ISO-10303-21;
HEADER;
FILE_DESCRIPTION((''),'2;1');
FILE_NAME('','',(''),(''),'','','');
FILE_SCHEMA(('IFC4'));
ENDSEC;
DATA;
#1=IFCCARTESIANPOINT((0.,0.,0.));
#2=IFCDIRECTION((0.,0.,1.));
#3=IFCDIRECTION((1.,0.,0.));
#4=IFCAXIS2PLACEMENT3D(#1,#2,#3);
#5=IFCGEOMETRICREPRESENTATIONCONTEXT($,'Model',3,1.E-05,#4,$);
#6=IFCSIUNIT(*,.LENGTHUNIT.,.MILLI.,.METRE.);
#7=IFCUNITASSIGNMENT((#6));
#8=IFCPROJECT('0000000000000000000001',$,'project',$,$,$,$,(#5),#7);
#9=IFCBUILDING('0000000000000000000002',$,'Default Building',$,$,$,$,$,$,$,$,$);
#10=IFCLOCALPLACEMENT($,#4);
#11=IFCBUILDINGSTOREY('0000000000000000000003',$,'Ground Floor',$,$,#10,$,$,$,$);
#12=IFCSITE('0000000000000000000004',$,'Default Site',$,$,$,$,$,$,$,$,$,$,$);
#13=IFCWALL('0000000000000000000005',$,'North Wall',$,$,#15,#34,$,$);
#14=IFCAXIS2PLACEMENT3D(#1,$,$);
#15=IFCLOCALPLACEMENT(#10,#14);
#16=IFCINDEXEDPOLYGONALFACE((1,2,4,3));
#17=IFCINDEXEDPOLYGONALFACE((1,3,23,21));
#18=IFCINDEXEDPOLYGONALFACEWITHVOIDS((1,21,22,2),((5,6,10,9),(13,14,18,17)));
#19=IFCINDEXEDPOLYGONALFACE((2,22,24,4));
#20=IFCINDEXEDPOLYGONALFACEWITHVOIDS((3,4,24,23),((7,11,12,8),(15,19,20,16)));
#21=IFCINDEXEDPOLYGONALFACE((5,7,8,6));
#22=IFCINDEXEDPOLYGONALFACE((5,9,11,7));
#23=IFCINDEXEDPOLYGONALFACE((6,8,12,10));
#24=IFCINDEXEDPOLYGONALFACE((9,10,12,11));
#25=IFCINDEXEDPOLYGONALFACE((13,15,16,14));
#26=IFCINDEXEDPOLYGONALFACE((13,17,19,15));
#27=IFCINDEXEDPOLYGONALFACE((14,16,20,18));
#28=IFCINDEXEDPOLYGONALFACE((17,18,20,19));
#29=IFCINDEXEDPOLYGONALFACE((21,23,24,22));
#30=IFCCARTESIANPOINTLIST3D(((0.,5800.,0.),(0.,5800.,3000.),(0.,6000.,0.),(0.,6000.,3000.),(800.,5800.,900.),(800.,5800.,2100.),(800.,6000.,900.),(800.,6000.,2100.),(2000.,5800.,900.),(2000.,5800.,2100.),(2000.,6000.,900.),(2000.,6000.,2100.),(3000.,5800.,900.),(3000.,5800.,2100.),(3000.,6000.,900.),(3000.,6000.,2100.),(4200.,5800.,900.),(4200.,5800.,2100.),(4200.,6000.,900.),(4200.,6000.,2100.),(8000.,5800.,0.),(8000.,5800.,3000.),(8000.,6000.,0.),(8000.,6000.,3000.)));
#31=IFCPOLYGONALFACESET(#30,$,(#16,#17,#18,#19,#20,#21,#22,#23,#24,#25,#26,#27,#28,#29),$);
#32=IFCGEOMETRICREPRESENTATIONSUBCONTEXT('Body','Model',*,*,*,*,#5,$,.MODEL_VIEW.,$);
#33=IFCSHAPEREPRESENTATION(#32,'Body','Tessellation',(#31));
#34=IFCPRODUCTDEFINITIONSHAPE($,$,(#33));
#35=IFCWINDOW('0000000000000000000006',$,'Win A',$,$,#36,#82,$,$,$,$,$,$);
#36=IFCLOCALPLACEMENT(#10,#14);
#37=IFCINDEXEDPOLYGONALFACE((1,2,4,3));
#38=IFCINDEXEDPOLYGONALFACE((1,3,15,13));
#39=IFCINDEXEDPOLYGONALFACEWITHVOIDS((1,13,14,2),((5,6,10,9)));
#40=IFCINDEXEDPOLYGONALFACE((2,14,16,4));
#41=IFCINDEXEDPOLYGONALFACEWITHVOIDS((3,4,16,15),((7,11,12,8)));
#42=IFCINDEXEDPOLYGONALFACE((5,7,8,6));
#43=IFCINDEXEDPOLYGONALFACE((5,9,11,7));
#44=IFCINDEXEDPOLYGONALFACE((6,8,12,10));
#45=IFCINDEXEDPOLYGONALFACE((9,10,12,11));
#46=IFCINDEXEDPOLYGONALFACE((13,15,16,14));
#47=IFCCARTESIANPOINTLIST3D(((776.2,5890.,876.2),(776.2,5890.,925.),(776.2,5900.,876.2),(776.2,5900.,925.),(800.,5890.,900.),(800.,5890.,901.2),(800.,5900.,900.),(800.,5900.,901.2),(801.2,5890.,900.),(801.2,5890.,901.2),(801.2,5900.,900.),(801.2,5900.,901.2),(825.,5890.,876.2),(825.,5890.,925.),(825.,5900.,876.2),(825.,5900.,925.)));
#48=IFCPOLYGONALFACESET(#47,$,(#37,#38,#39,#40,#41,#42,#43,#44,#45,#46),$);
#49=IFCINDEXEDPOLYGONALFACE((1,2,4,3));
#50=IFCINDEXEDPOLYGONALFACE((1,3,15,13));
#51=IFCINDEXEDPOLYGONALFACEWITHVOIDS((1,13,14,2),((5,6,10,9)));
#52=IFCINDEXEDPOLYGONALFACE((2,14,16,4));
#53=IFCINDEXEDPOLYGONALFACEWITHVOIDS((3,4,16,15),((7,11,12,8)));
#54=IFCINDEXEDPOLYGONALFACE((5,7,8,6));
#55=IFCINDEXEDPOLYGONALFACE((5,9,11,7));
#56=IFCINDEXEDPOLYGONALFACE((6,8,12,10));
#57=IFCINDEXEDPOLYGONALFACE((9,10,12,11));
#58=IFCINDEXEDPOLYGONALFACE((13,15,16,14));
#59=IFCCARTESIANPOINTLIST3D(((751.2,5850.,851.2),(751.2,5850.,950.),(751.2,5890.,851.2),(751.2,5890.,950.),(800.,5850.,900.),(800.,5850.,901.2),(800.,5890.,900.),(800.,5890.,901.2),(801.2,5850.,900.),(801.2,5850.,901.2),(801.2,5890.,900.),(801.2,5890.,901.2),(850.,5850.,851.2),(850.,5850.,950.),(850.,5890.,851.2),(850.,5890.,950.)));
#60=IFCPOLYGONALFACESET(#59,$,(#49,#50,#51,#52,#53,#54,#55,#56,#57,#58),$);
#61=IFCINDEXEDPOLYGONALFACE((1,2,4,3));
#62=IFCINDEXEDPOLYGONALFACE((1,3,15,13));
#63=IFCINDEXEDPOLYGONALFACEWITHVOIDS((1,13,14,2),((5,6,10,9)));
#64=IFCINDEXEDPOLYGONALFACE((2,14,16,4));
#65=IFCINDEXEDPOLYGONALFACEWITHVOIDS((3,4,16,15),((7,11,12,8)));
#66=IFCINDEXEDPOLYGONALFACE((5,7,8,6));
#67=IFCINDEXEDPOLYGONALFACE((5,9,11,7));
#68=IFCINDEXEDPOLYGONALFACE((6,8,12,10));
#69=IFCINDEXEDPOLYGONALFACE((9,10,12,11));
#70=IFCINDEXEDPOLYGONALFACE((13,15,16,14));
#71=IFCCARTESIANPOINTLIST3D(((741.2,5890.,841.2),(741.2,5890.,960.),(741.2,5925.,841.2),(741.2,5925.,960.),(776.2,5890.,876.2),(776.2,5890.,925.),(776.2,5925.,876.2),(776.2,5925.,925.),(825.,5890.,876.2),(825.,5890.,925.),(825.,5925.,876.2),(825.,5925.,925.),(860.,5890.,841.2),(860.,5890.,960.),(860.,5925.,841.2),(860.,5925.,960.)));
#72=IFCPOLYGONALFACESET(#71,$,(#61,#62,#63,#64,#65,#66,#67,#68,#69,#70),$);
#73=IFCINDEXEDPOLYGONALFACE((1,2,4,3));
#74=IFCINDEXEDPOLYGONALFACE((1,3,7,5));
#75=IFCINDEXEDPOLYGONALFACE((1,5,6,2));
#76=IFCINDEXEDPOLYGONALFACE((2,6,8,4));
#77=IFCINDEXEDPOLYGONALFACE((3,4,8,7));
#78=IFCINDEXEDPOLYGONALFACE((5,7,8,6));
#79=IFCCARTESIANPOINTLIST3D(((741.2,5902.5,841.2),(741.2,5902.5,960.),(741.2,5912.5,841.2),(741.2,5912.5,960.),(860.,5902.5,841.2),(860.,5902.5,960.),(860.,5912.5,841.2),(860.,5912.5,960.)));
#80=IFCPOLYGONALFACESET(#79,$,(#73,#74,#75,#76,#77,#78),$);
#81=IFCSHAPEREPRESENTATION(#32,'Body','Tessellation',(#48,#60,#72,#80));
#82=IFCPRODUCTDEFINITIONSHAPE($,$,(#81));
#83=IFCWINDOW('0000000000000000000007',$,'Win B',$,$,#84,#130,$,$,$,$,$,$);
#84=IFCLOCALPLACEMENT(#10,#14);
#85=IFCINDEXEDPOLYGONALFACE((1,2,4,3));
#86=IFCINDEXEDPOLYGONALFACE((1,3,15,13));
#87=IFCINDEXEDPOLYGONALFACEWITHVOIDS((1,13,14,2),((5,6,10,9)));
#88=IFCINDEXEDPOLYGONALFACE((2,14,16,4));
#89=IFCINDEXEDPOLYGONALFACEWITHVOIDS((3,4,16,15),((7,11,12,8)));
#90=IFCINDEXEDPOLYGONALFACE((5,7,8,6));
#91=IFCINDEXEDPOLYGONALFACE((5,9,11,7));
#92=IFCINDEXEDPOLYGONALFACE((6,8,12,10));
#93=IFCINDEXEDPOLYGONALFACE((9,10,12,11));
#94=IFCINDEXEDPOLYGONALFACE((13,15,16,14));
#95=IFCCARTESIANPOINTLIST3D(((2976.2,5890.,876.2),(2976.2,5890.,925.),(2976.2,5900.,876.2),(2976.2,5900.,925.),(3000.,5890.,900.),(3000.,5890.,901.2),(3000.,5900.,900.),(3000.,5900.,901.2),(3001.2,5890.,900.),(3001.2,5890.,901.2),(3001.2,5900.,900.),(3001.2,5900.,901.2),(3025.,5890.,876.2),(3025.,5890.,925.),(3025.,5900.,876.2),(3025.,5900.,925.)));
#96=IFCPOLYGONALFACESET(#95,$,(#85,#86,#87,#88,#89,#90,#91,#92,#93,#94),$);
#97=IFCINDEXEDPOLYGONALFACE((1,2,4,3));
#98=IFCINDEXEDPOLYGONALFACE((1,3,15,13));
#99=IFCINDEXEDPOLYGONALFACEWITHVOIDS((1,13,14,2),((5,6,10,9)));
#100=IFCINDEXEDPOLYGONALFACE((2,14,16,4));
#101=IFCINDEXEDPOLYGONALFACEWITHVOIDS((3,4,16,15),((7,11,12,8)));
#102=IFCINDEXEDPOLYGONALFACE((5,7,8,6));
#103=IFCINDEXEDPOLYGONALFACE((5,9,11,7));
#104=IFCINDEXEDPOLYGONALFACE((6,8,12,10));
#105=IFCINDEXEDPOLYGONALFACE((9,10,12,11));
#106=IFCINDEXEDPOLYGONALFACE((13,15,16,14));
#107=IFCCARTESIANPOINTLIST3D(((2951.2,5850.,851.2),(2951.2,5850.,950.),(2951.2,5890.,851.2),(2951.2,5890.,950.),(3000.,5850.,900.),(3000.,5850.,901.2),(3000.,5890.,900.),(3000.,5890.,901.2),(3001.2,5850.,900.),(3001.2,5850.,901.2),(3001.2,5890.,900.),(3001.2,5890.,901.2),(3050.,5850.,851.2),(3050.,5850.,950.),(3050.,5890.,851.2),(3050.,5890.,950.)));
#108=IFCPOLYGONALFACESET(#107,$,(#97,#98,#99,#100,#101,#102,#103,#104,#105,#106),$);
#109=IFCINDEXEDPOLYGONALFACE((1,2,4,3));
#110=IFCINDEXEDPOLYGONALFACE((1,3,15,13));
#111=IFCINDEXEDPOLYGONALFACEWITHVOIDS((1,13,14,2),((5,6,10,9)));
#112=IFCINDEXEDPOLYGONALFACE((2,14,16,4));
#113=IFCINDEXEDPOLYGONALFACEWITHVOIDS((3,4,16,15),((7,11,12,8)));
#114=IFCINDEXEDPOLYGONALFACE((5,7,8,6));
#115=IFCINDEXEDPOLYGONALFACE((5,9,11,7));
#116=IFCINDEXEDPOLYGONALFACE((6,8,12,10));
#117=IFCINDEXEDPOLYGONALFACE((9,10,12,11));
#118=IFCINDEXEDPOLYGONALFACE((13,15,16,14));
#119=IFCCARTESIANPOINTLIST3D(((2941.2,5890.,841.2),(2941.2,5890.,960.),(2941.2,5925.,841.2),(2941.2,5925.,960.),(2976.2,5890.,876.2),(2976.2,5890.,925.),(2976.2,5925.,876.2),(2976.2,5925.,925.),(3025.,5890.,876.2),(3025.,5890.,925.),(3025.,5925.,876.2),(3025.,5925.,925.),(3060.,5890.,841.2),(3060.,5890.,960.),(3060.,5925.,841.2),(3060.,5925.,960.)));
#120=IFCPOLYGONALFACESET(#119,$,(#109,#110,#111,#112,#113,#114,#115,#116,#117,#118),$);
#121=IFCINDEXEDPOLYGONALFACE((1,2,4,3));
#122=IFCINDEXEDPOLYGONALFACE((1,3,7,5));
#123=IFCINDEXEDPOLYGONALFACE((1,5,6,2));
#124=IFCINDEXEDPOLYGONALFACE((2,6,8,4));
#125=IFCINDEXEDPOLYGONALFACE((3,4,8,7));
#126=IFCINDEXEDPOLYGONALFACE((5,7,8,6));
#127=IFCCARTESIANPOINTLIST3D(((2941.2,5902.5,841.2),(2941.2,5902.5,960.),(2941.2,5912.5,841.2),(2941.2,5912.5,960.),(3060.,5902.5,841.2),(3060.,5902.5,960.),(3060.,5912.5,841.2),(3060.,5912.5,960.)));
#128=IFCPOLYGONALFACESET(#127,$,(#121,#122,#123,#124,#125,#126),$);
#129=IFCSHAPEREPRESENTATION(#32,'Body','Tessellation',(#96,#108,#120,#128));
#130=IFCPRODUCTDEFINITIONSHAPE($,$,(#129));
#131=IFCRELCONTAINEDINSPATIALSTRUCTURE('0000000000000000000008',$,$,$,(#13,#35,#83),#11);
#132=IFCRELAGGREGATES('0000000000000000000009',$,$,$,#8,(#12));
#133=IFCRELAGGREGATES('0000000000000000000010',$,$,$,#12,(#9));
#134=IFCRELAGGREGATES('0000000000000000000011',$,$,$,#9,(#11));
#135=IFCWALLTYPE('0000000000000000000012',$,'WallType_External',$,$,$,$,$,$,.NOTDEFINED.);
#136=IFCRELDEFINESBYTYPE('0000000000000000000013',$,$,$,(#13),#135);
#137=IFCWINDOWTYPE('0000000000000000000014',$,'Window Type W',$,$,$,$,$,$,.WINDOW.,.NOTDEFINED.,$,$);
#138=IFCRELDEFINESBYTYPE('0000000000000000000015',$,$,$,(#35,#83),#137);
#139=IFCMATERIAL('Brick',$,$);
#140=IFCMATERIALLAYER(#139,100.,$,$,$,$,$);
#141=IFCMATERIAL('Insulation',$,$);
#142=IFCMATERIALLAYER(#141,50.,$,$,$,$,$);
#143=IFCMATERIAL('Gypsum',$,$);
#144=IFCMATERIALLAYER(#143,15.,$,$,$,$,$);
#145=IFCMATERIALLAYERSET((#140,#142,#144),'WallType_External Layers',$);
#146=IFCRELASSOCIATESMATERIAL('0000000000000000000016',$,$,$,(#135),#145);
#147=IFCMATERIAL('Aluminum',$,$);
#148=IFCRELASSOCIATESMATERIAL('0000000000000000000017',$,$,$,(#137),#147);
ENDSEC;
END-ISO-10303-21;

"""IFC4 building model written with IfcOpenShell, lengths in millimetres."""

from ifc_helpers import new_model, si_unit, frame, origin_with_axes, place, context, subcontext, project, spatial, line, indexed_curve, outline, extrude, material, layer, layer_set, type_object, element, fill, save


model = new_model("IFC4")

# Units and contexts
model_context = context("Model", 3, precision=1e-05, world=origin_with_axes())
body_context = subcontext(model_context, "Body", "Model", "MODEL_VIEW")
ifc_project = project(units=[si_unit("LENGTHUNIT", "METRE", prefix="MILLI")], contexts=[model_context])

# Site, building, storey
site = spatial("IfcSite", under=ifc_project, Name="Default Site")
building = spatial("IfcBuilding", under=site, Name="Default Building")
storey_placement = place(None, origin_with_axes())
storey = spatial("IfcBuildingStorey", under=building, at=storey_placement, Name="Ground Floor")

# Shared definitions
ifc_material_1 = material(Name="Brick")
ifc_layer_1 = layer(ifc_material_1, 100.0)
ifc_material_2 = material(Name="Insulation")
ifc_layer_2 = layer(ifc_material_2, 50.0)
ifc_material_3 = material(Name="Gypsum")
ifc_layer_3 = layer(ifc_material_3, 15.0)
ifc_layer_set_1 = layer_set([ifc_layer_1, ifc_layer_2, ifc_layer_3], Name="WallType_External Layers")
wall_type = type_object("IfcWallType", Name="WallType_External", PredefinedType="NOTDEFINED", material=ifc_layer_set_1)

# Shared definitions
ifc_material_4 = material(Name="Aluminum")
window_type = type_object("IfcWindowType", Name="Window Type W", PartitioningType="NOTDEFINED", PredefinedType="WINDOW", material=ifc_material_4)

# Wall, openings, windows
wall_1_placement = place(storey_placement, origin_with_axes())
wall_1 = element("IfcWall", 1, at=wall_1_placement, inside=storey, type_object=wall_type, Name="North Wall", context=body_context, shape_type="SweptSolid", body=[
    extrude(outline(indexed_curve([(0.0, 5800.0), (8000.0, 5800.0), (8000.0, 6000.0), (0.0, 6000.0), (0.0, 5800.0)])), None, (0.0, 0.0, 1.0), 3000.0),
])
opening_1_placement = place(wall_1_placement, frame((0.0, 0.0, 900.0), z_axis=(0.0, 0.0, 1.0), x_axis=(1.0, 0.0, 0.0)))
opening_1 = element("IfcOpeningElement", 2, at=opening_1_placement, cuts=wall_1, context=body_context, shape_type="SweptSolid", body=[
    extrude(outline(indexed_curve([(800.0, 5800.0), (2000.0, 5800.0), (2000.0, 6000.0), (800.0, 6000.0), (800.0, 5800.0)])), None, (0.0, 0.0, 1.0), 1200.0),
])
opening_2_placement = place(wall_1_placement, frame((0.0, 0.0, 900.0), z_axis=(0.0, 0.0, 1.0), x_axis=(1.0, 0.0, 0.0)))
opening_2 = element("IfcOpeningElement", 3, at=opening_2_placement, cuts=wall_1, context=body_context, shape_type="SweptSolid", body=[
    extrude(outline(indexed_curve([(3000.0, 5800.0), (4200.0, 5800.0), (4200.0, 6000.0), (3000.0, 6000.0), (3000.0, 5800.0)])), None, (0.0, 0.0, 1.0), 1200.0),
])
window_1_placement = place(storey_placement, frame((800.0, 5800.0, 900.0), z_axis=(0.0, 0.0, 1.0), x_axis=(1.0, 0.0, 0.0)))
window_1 = element("IfcWindow", 4, at=window_1_placement, inside=storey, type_object=window_type, Name="Win A", context=body_context, shape_type="SweptSolid", body=[
    extrude(outline(indexed_curve([(0.0, 0.0), (1.2, 0.0), (1.2, 1.2), (0.0, 1.2)], segments=[line(1, 2, 3, 4, 1)]), holes=[indexed_curve([(25.0, 25.0), (-23.8, 25.0), (-23.8, -23.8), (25.0, -23.8)], segments=[line(1, 2, 3, 4, 1)])]), frame((0.0, 90.0, 0.0), z_axis=(0.0, -1.0, 0.0), x_axis=(1.0, 0.0, 0.0)), (0.0, 0.0, -1.0), 10.0),
    extrude(outline(indexed_curve([(0.0, 0.0), (1.2, 0.0), (1.2, 1.2), (0.0, 1.2)], segments=[line(1, 2, 3, 4, 1)]), holes=[indexed_curve([(50.0, 50.0), (-48.8, 50.0), (-48.8, -48.8), (50.0, -48.8)], segments=[line(1, 2, 3, 4, 1)])]), frame((0.0, 50.0, 0.0), z_axis=(0.0, -1.0, 0.0), x_axis=(1.0, 0.0, 0.0)), (0.0, 0.0, -1.0), 40.0),
    extrude(outline(indexed_curve([(0.0, 0.0), (-48.8, 0.0), (-48.8, -48.8), (0.0, -48.8)], segments=[line(1, 2, 3, 4, 1)]), holes=[indexed_curve([(35.0, 35.0), (-83.8, 35.0), (-83.8, -83.8), (35.0, -83.8)], segments=[line(1, 2, 3, 4, 1)])]), frame((25.0, 90.0, 25.0), z_axis=(0.0, -1.0, 0.0), x_axis=(1.0, 0.0, 0.0)), (0.0, 0.0, -1.0), 35.0),
    extrude(outline(indexed_curve([(35.0, 35.0), (-83.8, 35.0), (-83.8, -83.8), (35.0, -83.8)], segments=[line(1, 2, 3, 4, 1)])), frame((25.0, 102.5, 25.0), z_axis=(0.0, -1.0, 0.0), x_axis=(1.0, 0.0, 0.0)), (0.0, 0.0, -1.0), 10.0),
])
fill(opening_1, window_1)
window_2_placement = place(storey_placement, frame((3000.0, 5800.0, 900.0), z_axis=(0.0, 0.0, 1.0), x_axis=(1.0, 0.0, 0.0)))
window_2 = element("IfcWindow", 5, at=window_2_placement, inside=storey, type_object=window_type, Name="Win B", context=body_context, shape_type="SweptSolid", body=[
    extrude(outline(indexed_curve([(0.0, 0.0), (1.2, 0.0), (1.2, 1.2), (0.0, 1.2)], segments=[line(1, 2, 3, 4, 1)]), holes=[indexed_curve([(25.0, 25.0), (-23.8, 25.0), (-23.8, -23.8), (25.0, -23.8)], segments=[line(1, 2, 3, 4, 1)])]), frame((0.0, 90.0, 0.0), z_axis=(0.0, -1.0, 0.0), x_axis=(1.0, 0.0, 0.0)), (0.0, 0.0, -1.0), 10.0),
    extrude(outline(indexed_curve([(0.0, 0.0), (1.2, 0.0), (1.2, 1.2), (0.0, 1.2)], segments=[line(1, 2, 3, 4, 1)]), holes=[indexed_curve([(50.0, 50.0), (-48.8, 50.0), (-48.8, -48.8), (50.0, -48.8)], segments=[line(1, 2, 3, 4, 1)])]), frame((0.0, 50.0, 0.0), z_axis=(0.0, -1.0, 0.0), x_axis=(1.0, 0.0, 0.0)), (0.0, 0.0, -1.0), 40.0),
    extrude(outline(indexed_curve([(0.0, 0.0), (-48.8, 0.0), (-48.8, -48.8), (0.0, -48.8)], segments=[line(1, 2, 3, 4, 1)]), holes=[indexed_curve([(35.0, 35.0), (-83.8, 35.0), (-83.8, -83.8), (35.0, -83.8)], segments=[line(1, 2, 3, 4, 1)])]), frame((25.0, 90.0, 25.0), z_axis=(0.0, -1.0, 0.0), x_axis=(1.0, 0.0, 0.0)), (0.0, 0.0, -1.0), 35.0),
    extrude(outline(indexed_curve([(35.0, 35.0), (-83.8, 35.0), (-83.8, -83.8), (35.0, -83.8)], segments=[line(1, 2, 3, 4, 1)])), frame((25.0, 102.5, 25.0), z_axis=(0.0, -1.0, 0.0), x_axis=(1.0, 0.0, 0.0)), (0.0, 0.0, -1.0), 10.0),
])
fill(opening_2, window_2)

save(model, "model.ifc")
